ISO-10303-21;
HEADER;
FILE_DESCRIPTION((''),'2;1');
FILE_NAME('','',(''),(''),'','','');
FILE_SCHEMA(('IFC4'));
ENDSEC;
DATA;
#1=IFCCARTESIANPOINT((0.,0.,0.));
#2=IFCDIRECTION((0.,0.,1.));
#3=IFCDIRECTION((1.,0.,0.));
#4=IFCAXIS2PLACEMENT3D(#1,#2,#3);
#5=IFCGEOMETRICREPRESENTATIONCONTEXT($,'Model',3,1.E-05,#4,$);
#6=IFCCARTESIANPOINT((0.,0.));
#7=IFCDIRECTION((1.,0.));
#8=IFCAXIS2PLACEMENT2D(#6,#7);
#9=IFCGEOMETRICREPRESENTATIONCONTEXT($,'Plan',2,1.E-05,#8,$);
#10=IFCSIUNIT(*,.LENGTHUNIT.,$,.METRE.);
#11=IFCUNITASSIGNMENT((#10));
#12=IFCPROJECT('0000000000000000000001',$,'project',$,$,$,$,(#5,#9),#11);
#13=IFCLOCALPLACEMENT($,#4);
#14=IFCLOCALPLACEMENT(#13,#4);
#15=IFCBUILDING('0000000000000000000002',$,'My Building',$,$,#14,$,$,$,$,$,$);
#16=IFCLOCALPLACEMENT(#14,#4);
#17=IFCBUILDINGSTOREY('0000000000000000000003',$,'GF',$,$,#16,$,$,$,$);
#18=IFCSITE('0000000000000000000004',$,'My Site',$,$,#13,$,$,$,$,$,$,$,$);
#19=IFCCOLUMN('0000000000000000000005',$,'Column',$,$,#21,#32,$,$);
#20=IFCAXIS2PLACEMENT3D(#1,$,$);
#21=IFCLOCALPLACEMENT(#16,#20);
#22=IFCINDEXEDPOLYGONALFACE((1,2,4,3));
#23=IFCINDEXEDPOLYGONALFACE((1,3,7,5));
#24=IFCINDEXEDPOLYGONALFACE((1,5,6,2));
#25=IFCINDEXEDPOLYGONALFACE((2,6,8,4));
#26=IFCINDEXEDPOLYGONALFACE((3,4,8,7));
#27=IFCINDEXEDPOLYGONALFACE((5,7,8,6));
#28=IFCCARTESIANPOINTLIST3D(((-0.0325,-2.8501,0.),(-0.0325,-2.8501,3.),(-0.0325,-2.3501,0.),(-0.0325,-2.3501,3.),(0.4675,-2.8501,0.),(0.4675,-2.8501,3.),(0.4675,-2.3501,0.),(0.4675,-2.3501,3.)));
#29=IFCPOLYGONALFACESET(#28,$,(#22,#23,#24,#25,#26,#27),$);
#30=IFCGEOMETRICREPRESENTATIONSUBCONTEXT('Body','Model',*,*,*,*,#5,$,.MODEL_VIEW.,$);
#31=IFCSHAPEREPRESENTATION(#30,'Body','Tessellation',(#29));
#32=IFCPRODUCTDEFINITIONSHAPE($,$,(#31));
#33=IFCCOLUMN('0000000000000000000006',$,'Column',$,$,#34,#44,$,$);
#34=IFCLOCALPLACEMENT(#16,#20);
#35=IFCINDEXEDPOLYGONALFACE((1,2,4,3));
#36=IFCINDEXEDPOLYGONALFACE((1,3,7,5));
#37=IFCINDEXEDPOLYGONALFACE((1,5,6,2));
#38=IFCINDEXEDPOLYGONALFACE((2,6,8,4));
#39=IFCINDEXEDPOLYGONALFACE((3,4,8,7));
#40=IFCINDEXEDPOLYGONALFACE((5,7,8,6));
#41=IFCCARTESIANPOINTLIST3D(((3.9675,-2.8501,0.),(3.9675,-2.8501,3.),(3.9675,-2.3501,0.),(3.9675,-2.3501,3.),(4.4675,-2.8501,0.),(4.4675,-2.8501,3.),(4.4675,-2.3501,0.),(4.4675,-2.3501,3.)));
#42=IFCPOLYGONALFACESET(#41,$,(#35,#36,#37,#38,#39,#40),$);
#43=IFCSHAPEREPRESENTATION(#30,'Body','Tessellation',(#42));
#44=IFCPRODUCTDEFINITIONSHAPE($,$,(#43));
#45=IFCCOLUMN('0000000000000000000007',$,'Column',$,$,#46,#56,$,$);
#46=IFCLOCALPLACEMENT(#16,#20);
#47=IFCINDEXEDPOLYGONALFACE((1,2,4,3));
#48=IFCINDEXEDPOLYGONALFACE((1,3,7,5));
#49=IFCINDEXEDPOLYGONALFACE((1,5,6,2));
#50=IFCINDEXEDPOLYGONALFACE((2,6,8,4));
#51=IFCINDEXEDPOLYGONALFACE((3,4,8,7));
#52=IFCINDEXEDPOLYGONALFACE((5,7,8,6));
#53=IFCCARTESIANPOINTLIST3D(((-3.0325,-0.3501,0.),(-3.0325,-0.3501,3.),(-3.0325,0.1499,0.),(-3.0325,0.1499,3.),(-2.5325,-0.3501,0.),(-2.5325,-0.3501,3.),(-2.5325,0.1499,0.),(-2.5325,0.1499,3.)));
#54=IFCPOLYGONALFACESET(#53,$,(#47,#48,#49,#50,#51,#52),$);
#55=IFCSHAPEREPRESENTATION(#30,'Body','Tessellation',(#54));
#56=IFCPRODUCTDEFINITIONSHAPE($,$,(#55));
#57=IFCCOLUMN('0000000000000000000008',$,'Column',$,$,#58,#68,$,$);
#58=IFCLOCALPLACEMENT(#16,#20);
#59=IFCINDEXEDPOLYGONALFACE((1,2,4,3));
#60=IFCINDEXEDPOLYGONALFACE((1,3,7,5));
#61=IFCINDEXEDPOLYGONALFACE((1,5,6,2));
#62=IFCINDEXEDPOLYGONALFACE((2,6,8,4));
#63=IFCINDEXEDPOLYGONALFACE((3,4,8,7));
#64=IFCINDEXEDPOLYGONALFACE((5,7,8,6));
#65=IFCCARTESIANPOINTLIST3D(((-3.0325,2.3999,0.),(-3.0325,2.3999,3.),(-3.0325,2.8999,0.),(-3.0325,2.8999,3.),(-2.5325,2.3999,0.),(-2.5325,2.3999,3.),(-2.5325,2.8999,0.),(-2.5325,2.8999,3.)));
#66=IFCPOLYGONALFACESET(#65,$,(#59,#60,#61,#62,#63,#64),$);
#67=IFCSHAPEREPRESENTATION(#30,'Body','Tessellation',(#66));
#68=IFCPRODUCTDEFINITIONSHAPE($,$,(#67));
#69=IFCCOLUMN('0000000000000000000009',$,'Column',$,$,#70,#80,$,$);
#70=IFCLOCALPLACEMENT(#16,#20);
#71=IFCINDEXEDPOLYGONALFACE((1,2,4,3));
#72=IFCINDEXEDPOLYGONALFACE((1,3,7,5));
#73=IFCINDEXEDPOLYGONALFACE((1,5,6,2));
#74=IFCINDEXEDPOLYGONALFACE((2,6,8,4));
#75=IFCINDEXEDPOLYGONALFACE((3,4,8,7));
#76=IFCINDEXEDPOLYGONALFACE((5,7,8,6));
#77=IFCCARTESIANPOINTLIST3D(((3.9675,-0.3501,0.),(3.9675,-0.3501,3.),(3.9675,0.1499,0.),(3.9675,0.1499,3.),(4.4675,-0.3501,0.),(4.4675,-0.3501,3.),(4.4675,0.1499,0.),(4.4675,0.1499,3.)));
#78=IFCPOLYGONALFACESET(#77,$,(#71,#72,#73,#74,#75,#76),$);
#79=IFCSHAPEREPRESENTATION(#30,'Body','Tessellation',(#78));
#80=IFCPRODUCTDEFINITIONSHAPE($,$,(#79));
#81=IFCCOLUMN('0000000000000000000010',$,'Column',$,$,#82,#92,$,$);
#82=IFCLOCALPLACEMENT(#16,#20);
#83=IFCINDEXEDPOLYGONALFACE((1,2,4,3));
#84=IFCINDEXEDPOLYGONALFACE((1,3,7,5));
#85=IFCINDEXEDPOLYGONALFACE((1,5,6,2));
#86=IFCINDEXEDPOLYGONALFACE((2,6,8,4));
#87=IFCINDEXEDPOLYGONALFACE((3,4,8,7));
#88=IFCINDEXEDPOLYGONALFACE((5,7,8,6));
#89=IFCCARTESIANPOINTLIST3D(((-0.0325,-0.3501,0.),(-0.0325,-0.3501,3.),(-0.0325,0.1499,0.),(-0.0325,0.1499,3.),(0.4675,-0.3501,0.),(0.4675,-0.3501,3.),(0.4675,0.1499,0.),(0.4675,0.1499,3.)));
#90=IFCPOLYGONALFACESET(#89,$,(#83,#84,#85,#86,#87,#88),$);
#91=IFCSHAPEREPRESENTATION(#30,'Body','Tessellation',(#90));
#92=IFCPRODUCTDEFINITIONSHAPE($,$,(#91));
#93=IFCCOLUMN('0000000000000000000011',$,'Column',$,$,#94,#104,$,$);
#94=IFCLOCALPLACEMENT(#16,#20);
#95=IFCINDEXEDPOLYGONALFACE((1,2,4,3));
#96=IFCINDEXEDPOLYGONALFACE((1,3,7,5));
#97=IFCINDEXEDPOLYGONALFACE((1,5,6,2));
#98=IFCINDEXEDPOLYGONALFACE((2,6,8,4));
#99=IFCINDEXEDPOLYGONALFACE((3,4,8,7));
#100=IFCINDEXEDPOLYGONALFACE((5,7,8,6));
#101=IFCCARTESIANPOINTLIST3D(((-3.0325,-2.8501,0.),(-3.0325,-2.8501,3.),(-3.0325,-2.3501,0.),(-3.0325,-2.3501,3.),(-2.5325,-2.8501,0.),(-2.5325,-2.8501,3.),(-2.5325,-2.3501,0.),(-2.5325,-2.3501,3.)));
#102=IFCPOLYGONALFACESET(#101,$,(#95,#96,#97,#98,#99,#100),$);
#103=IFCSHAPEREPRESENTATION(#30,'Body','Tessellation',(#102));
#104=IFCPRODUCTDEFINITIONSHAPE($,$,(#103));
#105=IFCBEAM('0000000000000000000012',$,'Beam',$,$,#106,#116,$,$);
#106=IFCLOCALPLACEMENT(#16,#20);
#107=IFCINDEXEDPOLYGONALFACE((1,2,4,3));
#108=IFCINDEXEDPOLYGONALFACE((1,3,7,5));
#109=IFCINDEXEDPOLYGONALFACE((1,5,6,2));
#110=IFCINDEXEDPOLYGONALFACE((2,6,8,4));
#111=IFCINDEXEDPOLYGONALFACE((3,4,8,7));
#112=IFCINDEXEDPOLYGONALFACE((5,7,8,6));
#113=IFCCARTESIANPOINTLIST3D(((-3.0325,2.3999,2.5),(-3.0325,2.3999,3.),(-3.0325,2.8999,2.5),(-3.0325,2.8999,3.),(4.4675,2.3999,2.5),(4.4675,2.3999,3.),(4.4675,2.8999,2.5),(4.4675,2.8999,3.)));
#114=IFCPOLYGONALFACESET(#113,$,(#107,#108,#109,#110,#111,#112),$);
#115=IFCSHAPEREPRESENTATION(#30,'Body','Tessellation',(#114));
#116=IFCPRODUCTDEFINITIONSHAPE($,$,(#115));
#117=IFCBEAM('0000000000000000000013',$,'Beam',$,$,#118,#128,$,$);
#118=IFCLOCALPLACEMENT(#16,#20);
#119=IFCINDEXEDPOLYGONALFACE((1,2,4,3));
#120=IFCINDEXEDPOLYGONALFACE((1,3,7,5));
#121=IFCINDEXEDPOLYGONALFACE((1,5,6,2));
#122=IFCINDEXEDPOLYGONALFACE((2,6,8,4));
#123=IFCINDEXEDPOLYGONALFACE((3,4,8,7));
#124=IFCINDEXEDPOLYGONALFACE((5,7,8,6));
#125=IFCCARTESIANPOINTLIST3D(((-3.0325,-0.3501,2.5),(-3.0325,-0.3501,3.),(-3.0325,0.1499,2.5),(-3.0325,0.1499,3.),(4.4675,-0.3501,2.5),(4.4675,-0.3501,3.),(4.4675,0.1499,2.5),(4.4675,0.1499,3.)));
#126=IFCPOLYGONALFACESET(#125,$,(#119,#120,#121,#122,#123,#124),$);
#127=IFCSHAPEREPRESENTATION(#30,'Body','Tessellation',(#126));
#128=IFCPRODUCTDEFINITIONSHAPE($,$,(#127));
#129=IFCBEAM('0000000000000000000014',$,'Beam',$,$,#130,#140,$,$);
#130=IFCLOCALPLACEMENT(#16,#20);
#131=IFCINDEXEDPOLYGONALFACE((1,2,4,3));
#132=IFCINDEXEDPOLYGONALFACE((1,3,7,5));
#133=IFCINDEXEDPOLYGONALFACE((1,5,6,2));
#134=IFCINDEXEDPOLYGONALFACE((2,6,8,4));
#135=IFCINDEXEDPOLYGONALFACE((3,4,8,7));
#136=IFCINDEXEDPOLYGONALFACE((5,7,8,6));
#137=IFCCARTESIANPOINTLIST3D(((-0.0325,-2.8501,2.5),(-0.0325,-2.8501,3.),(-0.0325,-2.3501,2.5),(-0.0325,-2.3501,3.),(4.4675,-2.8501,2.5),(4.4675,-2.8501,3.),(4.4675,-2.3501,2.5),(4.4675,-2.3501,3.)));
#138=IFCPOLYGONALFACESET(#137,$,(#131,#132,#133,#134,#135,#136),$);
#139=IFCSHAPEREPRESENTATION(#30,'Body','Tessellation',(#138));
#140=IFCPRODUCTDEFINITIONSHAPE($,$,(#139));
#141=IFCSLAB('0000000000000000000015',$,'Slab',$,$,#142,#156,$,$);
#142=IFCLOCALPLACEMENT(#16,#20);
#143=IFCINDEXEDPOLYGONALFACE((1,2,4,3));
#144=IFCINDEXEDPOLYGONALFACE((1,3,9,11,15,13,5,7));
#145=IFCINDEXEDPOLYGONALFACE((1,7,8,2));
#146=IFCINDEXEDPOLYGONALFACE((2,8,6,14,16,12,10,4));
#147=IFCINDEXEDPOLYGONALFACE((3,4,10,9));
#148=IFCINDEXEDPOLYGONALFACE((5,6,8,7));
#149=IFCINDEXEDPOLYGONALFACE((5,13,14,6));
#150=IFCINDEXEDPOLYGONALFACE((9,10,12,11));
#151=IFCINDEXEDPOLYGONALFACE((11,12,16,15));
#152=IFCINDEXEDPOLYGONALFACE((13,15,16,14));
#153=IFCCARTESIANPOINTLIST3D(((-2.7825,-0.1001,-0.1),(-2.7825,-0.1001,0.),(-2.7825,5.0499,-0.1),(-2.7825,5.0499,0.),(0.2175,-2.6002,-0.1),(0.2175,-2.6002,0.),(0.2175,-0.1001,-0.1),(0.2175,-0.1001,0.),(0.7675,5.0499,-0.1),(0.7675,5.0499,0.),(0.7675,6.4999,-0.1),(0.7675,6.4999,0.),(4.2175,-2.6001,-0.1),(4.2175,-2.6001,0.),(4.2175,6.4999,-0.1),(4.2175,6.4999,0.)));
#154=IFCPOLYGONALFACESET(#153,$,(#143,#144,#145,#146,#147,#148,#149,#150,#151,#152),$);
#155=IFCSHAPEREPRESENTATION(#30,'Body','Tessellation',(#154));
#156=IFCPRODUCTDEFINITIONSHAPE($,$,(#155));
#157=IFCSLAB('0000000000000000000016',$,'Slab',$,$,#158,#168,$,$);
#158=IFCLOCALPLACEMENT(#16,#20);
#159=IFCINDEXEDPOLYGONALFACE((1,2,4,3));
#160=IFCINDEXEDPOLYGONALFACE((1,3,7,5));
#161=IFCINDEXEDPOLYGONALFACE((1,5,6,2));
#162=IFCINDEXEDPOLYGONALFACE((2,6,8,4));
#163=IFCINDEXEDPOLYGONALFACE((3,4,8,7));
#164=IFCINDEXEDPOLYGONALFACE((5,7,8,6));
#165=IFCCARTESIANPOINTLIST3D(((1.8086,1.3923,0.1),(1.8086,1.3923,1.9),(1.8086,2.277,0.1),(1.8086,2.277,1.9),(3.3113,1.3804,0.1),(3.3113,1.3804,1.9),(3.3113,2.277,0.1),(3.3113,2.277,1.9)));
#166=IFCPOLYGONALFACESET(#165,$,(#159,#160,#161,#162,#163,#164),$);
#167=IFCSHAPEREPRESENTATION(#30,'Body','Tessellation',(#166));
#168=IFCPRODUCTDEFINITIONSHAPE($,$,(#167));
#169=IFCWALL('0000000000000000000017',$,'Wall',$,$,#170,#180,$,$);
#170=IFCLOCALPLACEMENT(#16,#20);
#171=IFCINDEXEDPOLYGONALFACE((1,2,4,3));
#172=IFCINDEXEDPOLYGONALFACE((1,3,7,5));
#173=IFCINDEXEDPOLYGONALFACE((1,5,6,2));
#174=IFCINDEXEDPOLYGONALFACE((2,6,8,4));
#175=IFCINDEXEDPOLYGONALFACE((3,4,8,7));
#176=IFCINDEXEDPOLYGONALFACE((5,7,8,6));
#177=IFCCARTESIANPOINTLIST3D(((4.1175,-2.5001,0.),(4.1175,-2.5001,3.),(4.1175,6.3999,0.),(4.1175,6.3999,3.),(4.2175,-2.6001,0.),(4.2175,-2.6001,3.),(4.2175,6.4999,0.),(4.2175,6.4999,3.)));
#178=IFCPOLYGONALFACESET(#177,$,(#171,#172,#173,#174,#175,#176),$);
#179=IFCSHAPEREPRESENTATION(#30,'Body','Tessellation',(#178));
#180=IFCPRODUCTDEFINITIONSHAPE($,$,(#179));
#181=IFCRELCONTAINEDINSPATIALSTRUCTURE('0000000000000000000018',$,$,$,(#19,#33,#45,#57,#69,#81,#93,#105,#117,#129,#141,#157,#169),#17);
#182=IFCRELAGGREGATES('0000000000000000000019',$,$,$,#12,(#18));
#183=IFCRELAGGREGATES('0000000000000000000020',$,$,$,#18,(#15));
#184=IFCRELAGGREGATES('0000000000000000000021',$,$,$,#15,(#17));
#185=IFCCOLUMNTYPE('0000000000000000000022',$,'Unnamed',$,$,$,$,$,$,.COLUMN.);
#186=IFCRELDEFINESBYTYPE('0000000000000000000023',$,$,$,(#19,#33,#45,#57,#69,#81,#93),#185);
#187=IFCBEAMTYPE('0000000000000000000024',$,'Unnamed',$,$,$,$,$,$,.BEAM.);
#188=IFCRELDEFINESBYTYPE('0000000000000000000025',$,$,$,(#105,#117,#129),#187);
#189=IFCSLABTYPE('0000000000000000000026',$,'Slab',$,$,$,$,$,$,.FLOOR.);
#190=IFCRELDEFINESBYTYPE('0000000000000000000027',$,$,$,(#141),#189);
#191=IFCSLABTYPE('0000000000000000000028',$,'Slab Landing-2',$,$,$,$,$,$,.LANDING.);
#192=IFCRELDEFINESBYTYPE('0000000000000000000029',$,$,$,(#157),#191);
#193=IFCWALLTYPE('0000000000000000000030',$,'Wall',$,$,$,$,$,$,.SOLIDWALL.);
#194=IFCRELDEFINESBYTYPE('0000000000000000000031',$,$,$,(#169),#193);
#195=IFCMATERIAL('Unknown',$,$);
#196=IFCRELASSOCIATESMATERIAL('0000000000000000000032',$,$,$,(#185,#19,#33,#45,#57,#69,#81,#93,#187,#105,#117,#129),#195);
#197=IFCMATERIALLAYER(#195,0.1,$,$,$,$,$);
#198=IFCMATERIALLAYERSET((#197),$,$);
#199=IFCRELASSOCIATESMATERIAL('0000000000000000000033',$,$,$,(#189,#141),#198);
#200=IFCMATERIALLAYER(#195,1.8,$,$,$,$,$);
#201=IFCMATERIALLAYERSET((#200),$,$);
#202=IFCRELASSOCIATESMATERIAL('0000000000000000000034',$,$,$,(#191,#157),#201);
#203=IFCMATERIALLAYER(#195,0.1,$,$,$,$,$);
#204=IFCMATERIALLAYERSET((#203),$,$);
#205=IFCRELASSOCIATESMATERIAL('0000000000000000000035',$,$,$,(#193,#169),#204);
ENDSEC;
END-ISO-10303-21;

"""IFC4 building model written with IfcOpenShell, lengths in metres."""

from ifc_helpers import new_model, si_unit, frame, origin_with_axes, origin_2d_with_axis, place, context, subcontext, project, spatial, line, indexed_curve, rectangle, outline, extrude, material, layer, layer_set, layer_usage, material_profile, profile_set, profile_usage, type_object, element, save


model = new_model("IFC4")

# Units and contexts
model_context = context("Model", 3, precision=1e-05, world=origin_with_axes())
plan_context = context("Plan", 2, precision=1e-05, world=origin_2d_with_axis())
body_context_1 = subcontext(model_context, "Body", "Model", "MODEL_VIEW")
ifc_project = project(units=[si_unit("LENGTHUNIT", "METRE")], contexts=[model_context, plan_context])

# Site, building, storey
site_placement = place(None, origin_with_axes())
site = spatial("IfcSite", under=ifc_project, at=site_placement, Name="My Site")
building_placement = place(site_placement, origin_with_axes())
building = spatial("IfcBuilding", under=site, at=building_placement, Name="My Building")
storey_placement = place(building_placement, origin_with_axes())
storey = spatial("IfcBuildingStorey", under=building, at=storey_placement, Name="GF")

# Columns
ifc_material = material(Name="Unknown")
ifc_material_profile_1 = material_profile(ifc_material, rectangle(XDim=0.5, YDim=0.5))
ifc_profile_set_1 = profile_set([ifc_material_profile_1])
ifc_profile_usage_1 = profile_usage(ifc_profile_set_1, cardinal=5)
column_type = type_object("IfcColumnType", Name="Unnamed", PredefinedType="COLUMN", material=ifc_profile_set_1)
column_1_placement = place(storey_placement, frame((0.2175, -2.6001, 0.0), z_axis=(0.0, 0.0, 1.0), x_axis=(1.0, 0.0, 0.0)))
element("IfcColumn", 1, at=column_1_placement, inside=storey, type_object=column_type, material=ifc_profile_usage_1, Name="Column", context=body_context_1, shape_type="SweptSolid", body=[
    extrude(rectangle(XDim=0.5, YDim=0.5), origin_with_axes(), (0.0, 0.0, 1.0), 3.0),
])
ifc_profile_usage_2 = profile_usage(ifc_profile_set_1, cardinal=5)
column_2_placement = place(storey_placement, frame((4.2175, -2.6001, 0.0), z_axis=(0.0, 0.0, 1.0), x_axis=(1.0, 0.0, 0.0)))
element("IfcColumn", 2, at=column_2_placement, inside=storey, type_object=column_type, material=ifc_profile_usage_2, Name="Column", context=body_context_1, shape_type="SweptSolid", body=[
    extrude(rectangle(XDim=0.5, YDim=0.5), origin_with_axes(), (0.0, 0.0, 1.0), 3.0),
])
ifc_profile_usage_3 = profile_usage(ifc_profile_set_1, cardinal=5)
column_3_placement = place(storey_placement, frame((-2.7825, -0.1001, 0.0), z_axis=(0.0, 0.0, 1.0), x_axis=(1.0, 0.0, 0.0)))
element("IfcColumn", 3, at=column_3_placement, inside=storey, type_object=column_type, material=ifc_profile_usage_3, Name="Column", context=body_context_1, shape_type="SweptSolid", body=[
    extrude(rectangle(XDim=0.5, YDim=0.5), origin_with_axes(), (0.0, 0.0, 1.0), 3.0),
])
ifc_profile_usage_4 = profile_usage(ifc_profile_set_1, cardinal=5)
column_4_placement = place(storey_placement, frame((-2.7825, 2.6499, 0.0), z_axis=(0.0, 0.0, 1.0), x_axis=(1.0, 0.0, 0.0)))
element("IfcColumn", 4, at=column_4_placement, inside=storey, type_object=column_type, material=ifc_profile_usage_4, Name="Column", context=body_context_1, shape_type="SweptSolid", body=[
    extrude(rectangle(XDim=0.5, YDim=0.5), origin_with_axes(), (0.0, 0.0, 1.0), 3.0),
])
ifc_profile_usage_5 = profile_usage(ifc_profile_set_1, cardinal=5)
column_5_placement = place(storey_placement, frame((4.2175, -0.1001, 0.0), z_axis=(0.0, 0.0, 1.0), x_axis=(1.0, 0.0, 0.0)))
element("IfcColumn", 5, at=column_5_placement, inside=storey, type_object=column_type, material=ifc_profile_usage_5, Name="Column", context=body_context_1, shape_type="SweptSolid", body=[
    extrude(rectangle(XDim=0.5, YDim=0.5), origin_with_axes(), (0.0, 0.0, 1.0), 3.0),
])
ifc_profile_usage_6 = profile_usage(ifc_profile_set_1, cardinal=5)
column_6_placement = place(storey_placement, frame((0.2175, -0.1001, 0.0), z_axis=(0.0, 0.0, 1.0), x_axis=(1.0, 0.0, 0.0)))
element("IfcColumn", 6, at=column_6_placement, inside=storey, type_object=column_type, material=ifc_profile_usage_6, Name="Column", context=body_context_1, shape_type="SweptSolid", body=[
    extrude(rectangle(XDim=0.5, YDim=0.5), origin_with_axes(), (0.0, 0.0, 1.0), 3.0),
])
ifc_profile_usage_7 = profile_usage(ifc_profile_set_1, cardinal=5)
column_7_placement = place(storey_placement, frame((-2.7825, -2.6001, 0.0), z_axis=(0.0, 0.0, 1.0), x_axis=(1.0, 0.0, 0.0)))
element("IfcColumn", 7, at=column_7_placement, inside=storey, type_object=column_type, material=ifc_profile_usage_7, Name="Column", context=body_context_1, shape_type="SweptSolid", body=[
    extrude(rectangle(XDim=0.5, YDim=0.5), origin_with_axes(), (0.0, 0.0, 1.0), 3.0),
])

# Beams
ifc_material_profile_2 = material_profile(ifc_material, rectangle(XDim=0.5, YDim=0.5))
ifc_profile_set_2 = profile_set([ifc_material_profile_2])
ifc_profile_usage_8 = profile_usage(ifc_profile_set_2, cardinal=7)
beam_type = type_object("IfcBeamType", Name="Unnamed", PredefinedType="BEAM", material=ifc_profile_set_2)
beam_1_placement = place(storey_placement, frame((4.4675, 2.3999, 3.0), z_axis=(-1.0, 0.0, 0.0), x_axis=(0.0, -1.0, 0.0)))
element("IfcBeam", 8, at=beam_1_placement, inside=storey, type_object=beam_type, material=ifc_profile_usage_8, Name="Beam", context=body_context_1, shape_type="SweptSolid", body=[
    extrude(rectangle(XDim=0.5, YDim=0.5), frame((-0.25, -0.25, 0.0), z_axis=(0.0, 0.0, 1.0), x_axis=(1.0, 0.0, 0.0)), (0.0, 0.0, 1.0), 7.5),
])
ifc_profile_usage_9 = profile_usage(ifc_profile_set_2, cardinal=7)
beam_2_placement = place(storey_placement, frame((4.4675, -0.3501, 3.0), z_axis=(-1.0, 0.0, 0.0), x_axis=(0.0, -1.0, 0.0)))
element("IfcBeam", 9, at=beam_2_placement, inside=storey, type_object=beam_type, material=ifc_profile_usage_9, Name="Beam", context=body_context_1, shape_type="SweptSolid", body=[
    extrude(rectangle(XDim=0.5, YDim=0.5), frame((-0.25, -0.25, 0.0), z_axis=(0.0, 0.0, 1.0), x_axis=(1.0, 0.0, 0.0)), (0.0, 0.0, 1.0), 7.5),
])
ifc_profile_usage_10 = profile_usage(ifc_profile_set_2, cardinal=7)
beam_3_placement = place(storey_placement, frame((4.4675, -2.8501, 3.0), z_axis=(-1.0, 0.0, 0.0), x_axis=(0.0, -1.0, 0.0)))
element("IfcBeam", 10, at=beam_3_placement, inside=storey, type_object=beam_type, material=ifc_profile_usage_10, Name="Beam", context=body_context_1, shape_type="SweptSolid", body=[
    extrude(rectangle(XDim=0.5, YDim=0.5), frame((-0.25, -0.25, 0.0), z_axis=(0.0, 0.0, 1.0), x_axis=(1.0, 0.0, 0.0)), (0.0, 0.0, 1.0), 4.5),
])

# Slabs
ifc_layer_1 = layer(ifc_material, 0.1)
ifc_layer_set_1 = layer_set([ifc_layer_1])
ifc_layer_usage_1 = layer_usage(ifc_layer_set_1, "AXIS3", "POSITIVE", -0.1)
slab_type_1 = type_object("IfcSlabType", Name="Slab", PredefinedType="FLOOR", material=ifc_layer_set_1)
slab_1_placement = place(storey_placement, frame((4.2175, -2.6001, 0.0), z_axis=(0.0, 0.0, 1.0), x_axis=(1.0, 0.0, 0.0)))
element("IfcSlab", 11, at=slab_1_placement, inside=storey, type_object=slab_type_1, material=ifc_layer_usage_1, Name="Slab", context=body_context_1, shape_type="SweptSolid", body=[
    extrude(outline(indexed_curve([(0.0, 0.0), (0.0, 9.1), (-3.45, 9.1), (-3.45, 7.6499), (-7.0, 7.6499), (-7.0, 2.5), (-4.0, 2.5), (-4.0, -0.0001), (0.0, 0.0)])), frame((0.0, 0.0, -0.1), z_axis=(0.0, 0.0, 1.0), x_axis=(1.0, 0.0, 0.0)), (0.0, 0.0, 1.0), 0.1),
])
ifc_layer_2 = layer(ifc_material, 1.8)
ifc_layer_set_2 = layer_set([ifc_layer_2])
ifc_layer_usage_2 = layer_usage(ifc_layer_set_2, "AXIS3", "POSITIVE", -1.8)
slab_type_2 = type_object("IfcSlabType", Name="Slab Landing-2", PredefinedType="LANDING", material=ifc_layer_set_2)
slab_2_placement = place(storey_placement, frame((3.3113, 2.277, 1.9), z_axis=(0.0, 0.0, 1.0), x_axis=(1.0, 0.0, 0.0)))
element("IfcSlab", 12, at=slab_2_placement, inside=storey, type_object=slab_type_2, material=ifc_layer_usage_2, Name="Slab", context=body_context_1, shape_type="SweptSolid", body=[
    extrude(outline(indexed_curve([(0.0, 0.0), (0.0, -0.8966), (-1.5027, -0.8847), (-1.5027, 0.0), (0.0, 0.0)])), frame((0.0, 0.0, -1.8), z_axis=(0.0, 0.0, 1.0), x_axis=(1.0, 0.0, 0.0)), (0.0, 0.0, 1.0), 1.8),
])

# Shared definitions
ifc_layer_3 = layer(ifc_material, 0.1)
ifc_layer_set_3 = layer_set([ifc_layer_3])
wall_type = type_object("IfcWallType", Name="Wall", PredefinedType="SOLIDWALL", material=ifc_layer_set_3)

# Wall
ifc_layer_usage_3 = layer_usage(ifc_layer_set_3, "AXIS2", "POSITIVE", 0.0)
wall_1_placement = place(storey_placement, frame((4.2175, -2.6001, 0.0), z_axis=(0.0, 0.0, 1.0), x_axis=(0.0, 1.0, 0.0)))
element("IfcWall", 13, at=wall_1_placement, inside=storey, type_object=wall_type, material=ifc_layer_usage_3, Name="Wall", context=body_context_1, shape_type="SweptSolid", body=[
    extrude(outline(indexed_curve([(0.0, 0.0), (0.1, 0.1), (9.0, 0.1), (9.1, 0.0)], segments=[line(1, 2, 3, 4, 1)])), origin_with_axes(), (0.0, 0.0, 1.0), 3.0),
])

save(model, "model.ifc")
